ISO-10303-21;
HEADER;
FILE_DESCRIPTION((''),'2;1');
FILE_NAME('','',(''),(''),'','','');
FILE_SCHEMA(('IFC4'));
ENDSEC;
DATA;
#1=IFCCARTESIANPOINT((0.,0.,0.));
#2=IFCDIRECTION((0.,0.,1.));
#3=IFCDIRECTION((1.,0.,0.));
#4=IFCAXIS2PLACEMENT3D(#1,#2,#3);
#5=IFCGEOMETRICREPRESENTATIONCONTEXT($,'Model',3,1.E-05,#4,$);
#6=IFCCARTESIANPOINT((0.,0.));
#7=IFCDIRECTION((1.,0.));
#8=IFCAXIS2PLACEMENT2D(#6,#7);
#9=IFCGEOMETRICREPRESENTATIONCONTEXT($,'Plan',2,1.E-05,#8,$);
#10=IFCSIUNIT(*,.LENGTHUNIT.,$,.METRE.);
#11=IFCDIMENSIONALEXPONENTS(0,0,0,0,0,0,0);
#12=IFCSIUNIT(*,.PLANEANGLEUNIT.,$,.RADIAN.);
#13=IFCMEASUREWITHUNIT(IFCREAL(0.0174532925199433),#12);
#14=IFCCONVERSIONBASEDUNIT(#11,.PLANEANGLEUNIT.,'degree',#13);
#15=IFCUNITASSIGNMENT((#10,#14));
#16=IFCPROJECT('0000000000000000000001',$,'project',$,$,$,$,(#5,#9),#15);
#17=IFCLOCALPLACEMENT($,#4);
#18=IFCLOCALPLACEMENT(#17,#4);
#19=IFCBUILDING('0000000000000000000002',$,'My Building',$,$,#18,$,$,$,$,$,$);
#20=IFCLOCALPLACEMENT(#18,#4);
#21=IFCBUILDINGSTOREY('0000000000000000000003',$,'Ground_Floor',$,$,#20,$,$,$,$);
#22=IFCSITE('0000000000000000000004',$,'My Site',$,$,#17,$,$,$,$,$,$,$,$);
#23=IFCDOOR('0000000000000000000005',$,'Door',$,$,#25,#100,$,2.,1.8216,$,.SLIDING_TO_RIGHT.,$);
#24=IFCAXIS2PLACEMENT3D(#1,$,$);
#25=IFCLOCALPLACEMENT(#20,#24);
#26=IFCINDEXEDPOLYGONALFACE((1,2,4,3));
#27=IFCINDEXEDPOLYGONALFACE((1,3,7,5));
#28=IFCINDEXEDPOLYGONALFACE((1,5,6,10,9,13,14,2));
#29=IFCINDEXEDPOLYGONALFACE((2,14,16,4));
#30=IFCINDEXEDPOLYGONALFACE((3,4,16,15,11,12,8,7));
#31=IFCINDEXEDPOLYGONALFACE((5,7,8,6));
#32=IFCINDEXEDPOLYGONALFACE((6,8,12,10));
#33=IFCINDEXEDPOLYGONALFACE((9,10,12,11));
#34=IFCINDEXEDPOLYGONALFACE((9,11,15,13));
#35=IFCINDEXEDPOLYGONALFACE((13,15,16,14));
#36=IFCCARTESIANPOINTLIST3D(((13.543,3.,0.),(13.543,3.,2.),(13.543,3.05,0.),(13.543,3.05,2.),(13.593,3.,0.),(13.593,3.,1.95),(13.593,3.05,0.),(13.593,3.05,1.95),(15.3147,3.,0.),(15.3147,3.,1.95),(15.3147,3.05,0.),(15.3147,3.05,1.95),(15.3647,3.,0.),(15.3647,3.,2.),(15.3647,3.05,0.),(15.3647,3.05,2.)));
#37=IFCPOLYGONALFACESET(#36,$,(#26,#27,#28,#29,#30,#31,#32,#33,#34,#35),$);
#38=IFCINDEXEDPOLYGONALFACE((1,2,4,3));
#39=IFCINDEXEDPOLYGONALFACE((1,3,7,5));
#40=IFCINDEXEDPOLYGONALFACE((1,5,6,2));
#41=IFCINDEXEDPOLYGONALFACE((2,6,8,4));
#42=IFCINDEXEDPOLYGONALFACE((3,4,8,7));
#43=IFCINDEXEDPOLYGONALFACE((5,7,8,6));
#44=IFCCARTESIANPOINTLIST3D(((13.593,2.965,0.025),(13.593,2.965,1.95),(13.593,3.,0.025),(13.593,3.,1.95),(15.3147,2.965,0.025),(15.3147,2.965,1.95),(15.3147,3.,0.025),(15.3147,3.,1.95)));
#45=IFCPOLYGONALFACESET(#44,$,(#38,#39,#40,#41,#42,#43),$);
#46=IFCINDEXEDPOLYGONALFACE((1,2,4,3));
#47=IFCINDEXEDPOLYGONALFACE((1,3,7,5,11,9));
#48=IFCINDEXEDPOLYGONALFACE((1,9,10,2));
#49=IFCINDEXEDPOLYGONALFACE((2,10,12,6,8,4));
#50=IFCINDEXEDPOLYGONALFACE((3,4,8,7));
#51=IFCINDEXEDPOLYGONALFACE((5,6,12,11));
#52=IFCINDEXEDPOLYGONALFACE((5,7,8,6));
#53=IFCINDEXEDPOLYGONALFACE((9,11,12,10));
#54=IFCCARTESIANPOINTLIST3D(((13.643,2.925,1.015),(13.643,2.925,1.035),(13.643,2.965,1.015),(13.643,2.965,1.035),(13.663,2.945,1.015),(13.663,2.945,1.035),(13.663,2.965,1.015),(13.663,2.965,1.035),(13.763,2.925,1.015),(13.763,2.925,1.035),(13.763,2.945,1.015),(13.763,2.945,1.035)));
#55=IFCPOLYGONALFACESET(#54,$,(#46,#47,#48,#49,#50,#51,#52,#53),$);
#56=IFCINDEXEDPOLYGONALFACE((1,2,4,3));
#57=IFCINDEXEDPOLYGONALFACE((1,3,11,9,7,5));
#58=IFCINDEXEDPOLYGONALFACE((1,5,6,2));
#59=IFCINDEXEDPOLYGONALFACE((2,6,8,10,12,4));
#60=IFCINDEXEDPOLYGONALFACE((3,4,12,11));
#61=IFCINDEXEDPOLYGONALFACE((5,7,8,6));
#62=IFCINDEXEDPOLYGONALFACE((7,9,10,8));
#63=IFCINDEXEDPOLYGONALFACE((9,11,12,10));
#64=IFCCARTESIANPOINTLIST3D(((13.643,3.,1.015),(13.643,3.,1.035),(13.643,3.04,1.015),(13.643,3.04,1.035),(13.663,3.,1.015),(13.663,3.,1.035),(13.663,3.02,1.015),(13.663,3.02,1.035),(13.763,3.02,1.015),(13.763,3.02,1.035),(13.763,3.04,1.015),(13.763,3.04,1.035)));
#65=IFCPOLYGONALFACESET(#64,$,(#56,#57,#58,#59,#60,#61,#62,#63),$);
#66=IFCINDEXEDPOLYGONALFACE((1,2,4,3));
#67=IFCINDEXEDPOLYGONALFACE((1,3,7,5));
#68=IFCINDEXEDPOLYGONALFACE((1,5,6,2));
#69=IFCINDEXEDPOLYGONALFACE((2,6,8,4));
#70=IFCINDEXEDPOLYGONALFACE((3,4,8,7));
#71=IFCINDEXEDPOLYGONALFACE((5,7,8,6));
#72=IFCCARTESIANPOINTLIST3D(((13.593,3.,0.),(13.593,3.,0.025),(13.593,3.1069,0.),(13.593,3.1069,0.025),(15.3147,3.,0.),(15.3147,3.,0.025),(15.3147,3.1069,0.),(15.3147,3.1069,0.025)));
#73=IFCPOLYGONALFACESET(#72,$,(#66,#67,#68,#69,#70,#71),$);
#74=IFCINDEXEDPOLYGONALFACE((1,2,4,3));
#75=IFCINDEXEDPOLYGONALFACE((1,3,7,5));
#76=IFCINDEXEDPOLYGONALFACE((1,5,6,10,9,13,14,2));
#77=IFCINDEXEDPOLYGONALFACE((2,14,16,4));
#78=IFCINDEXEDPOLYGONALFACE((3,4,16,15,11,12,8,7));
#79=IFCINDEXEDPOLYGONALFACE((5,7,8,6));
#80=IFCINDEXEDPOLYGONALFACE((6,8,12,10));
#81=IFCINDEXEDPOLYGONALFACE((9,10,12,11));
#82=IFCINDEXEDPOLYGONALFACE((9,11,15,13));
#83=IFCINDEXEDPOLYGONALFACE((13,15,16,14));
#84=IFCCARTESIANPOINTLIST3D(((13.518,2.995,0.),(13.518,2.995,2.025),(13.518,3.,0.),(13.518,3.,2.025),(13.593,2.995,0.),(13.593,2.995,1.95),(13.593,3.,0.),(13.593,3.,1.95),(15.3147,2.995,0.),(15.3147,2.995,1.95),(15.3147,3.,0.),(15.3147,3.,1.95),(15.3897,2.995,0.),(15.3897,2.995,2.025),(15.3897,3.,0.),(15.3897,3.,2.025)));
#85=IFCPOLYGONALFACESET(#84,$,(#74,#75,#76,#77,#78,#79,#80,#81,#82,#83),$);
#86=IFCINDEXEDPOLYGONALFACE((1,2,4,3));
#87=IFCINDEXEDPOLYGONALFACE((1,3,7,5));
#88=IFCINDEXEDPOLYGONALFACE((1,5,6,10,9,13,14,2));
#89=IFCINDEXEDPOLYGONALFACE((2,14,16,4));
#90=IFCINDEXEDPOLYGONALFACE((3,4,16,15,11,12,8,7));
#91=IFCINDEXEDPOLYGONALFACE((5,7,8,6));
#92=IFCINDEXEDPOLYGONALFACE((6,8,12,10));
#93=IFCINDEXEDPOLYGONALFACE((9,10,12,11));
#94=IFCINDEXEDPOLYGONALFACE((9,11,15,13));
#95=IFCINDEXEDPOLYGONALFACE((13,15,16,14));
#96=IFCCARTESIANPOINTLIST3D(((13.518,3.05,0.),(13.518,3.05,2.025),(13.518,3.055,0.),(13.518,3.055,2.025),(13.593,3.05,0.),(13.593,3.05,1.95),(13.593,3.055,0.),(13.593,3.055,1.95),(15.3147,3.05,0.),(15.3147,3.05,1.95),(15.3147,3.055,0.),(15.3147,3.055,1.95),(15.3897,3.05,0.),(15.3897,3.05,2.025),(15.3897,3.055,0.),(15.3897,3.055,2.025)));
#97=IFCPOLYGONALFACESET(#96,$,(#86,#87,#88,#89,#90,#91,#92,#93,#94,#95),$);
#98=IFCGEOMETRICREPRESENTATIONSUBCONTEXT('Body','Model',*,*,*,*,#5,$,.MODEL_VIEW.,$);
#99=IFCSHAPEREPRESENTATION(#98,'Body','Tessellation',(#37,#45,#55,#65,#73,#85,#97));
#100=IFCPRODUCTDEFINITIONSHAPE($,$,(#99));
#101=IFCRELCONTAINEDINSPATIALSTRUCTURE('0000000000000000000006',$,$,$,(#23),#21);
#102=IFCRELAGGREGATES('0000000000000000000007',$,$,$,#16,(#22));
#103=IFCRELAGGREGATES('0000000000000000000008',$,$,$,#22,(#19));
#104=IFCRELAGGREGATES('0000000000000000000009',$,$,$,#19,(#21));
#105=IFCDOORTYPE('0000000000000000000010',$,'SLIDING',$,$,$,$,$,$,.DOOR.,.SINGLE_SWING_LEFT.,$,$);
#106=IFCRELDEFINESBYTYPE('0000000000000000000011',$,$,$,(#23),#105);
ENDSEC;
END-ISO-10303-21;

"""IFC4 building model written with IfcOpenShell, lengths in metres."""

from ifc_helpers import new_model, entity, si_unit, converted_unit, frame, origin_with_axes, origin_2d_with_axis, place, context, subcontext, project, spatial, line, indexed_curve, outline, extrude, shape, source, transform, mapped, type_object, type_shapes, element, save


model = new_model("IFC4")

# Units and contexts
model_context = context("Model", 3, precision=1e-05, world=origin_with_axes())
plan_context = context("Plan", 2, precision=1e-05, world=origin_2d_with_axis())
body_context_1 = subcontext(model_context, "Body", "Model", "MODEL_VIEW")
body_context_2 = subcontext(plan_context, "Body", "Plan", "PLAN_VIEW")
ifc_project = project(units=[si_unit("LENGTHUNIT", "METRE"), converted_unit("PLANEANGLEUNIT", "degree", entity("IfcReal", 0.0174532925199433), si_unit("PLANEANGLEUNIT", "RADIAN"), dimensions=[0, 0, 0, 0, 0, 0, 0])], contexts=[model_context, plan_context])

# Site, building, storey
site_placement = place(None, origin_with_axes())
site = spatial("IfcSite", under=ifc_project, at=site_placement, Name="My Site")
building_placement = place(site_placement, origin_with_axes())
building = spatial("IfcBuilding", under=site, at=building_placement, Name="My Building")
storey_placement = place(building_placement, origin_with_axes())
storey = spatial("IfcBuildingStorey", under=building, at=storey_placement, Name="Ground_Floor")

# Shared definitions
door_type_1 = type_object("IfcDoorType", Name="SLIDING", OperationType="SINGLE_SWING_LEFT", PredefinedType="DOOR")
shared_shape_1 = source(origin_with_axes(), body_context_1, "Body", "SweptSolid", [
    extrude(outline(indexed_curve([(0.0, 0.0), (0.0, 2.0), (1.8216, 2.0), (1.8216, 0.0), (1.7716, 0.0), (1.7716, 1.95), (0.05, 1.95), (0.05, 0.0)], segments=[line(1, 2, 3, 4, 5, 6, 7, 8, 1)])), frame((0.0, 0.0, 0.0), z_axis=(0.0, -1.0, 0.0), x_axis=(1.0, 0.0, 0.0)), (0.0, 0.0, -1.0), 0.05),
    extrude(outline(indexed_curve([(0.0, 0.0), (1.7216, 0.0), (1.7216, 0.035), (0.0, 0.035)], segments=[line(1, 2, 3, 4, 1)])), frame((0.05, -0.035, 0.025), z_axis=(0.0, 0.0, 1.0), x_axis=(1.0, 0.0, 0.0)), (0.0, 0.0, 1.0), 1.925),
    extrude(outline(indexed_curve([(0.0, 0.0), (0.0, -0.04), (0.12, -0.04), (0.12, -0.02), (0.02, -0.02), (0.02, 0.0)], segments=[line(1, 2, 3, 4, 5, 6, 1)])), frame((0.1, -0.035, 1.015), z_axis=(0.0, 0.0, 1.0), x_axis=(1.0, 0.0, 0.0)), (0.0, 0.0, 1.0), 0.02),
    extrude(outline(indexed_curve([(0.0, 0.0), (0.0, 0.04), (0.12, 0.04), (0.12, 0.02), (0.02, 0.02), (0.02, 0.0)], segments=[line(1, 2, 3, 4, 5, 6, 1)])), frame((0.1, 0.0, 1.015), z_axis=(0.0, 0.0, 1.0), x_axis=(1.0, 0.0, 0.0)), (0.0, 0.0, 1.0), 0.02),
    extrude(outline(indexed_curve([(0.0, 0.0), (1.7216, 0.0), (1.7216, 0.1069), (0.0, 0.1069)], segments=[line(1, 2, 3, 4, 1)])), frame((0.05, 0.0, 0.0), z_axis=(0.0, 0.0, 1.0), x_axis=(1.0, 0.0, 0.0)), (0.0, 0.0, 1.0), 0.025),
    extrude(outline(indexed_curve([(0.0, 0.0), (0.0, 2.025), (1.8716, 2.025), (1.8716, 0.0), (1.7966, 0.0), (1.7966, 1.95), (0.075, 1.95), (0.075, 0.0)], segments=[line(1, 2, 3, 4, 5, 6, 7, 8, 1)])), frame((-0.025, -0.005, 0.0), z_axis=(0.0, -1.0, 0.0), x_axis=(1.0, 0.0, 0.0)), (0.0, 0.0, -1.0), 0.005),
    extrude(outline(indexed_curve([(0.0, 0.0), (0.0, 2.025), (1.8716, 2.025), (1.8716, 0.0), (1.7966, 0.0), (1.7966, 1.95), (0.075, 1.95), (0.075, 0.0)], segments=[line(1, 2, 3, 4, 5, 6, 7, 8, 1)])), frame((-0.025, 0.05, 0.0), z_axis=(0.0, -1.0, 0.0), x_axis=(1.0, 0.0, 0.0)), (0.0, 0.0, -1.0), 0.005),
])
shared_shape_2 = source(origin_with_axes(), body_context_2, "Body", "Curve2D", [
    entity("IfcIndexedPolyCurve", entity("IfcCartesianPointList2D", [[0.0, 0.0], [0.05, 0.0], [0.05, 0.05], [0.0, 0.05]]), [entity("IfcLineIndex", [1, 2, 3, 4, 1])]),
    entity("IfcIndexedPolyCurve", entity("IfcCartesianPointList2D", [[1.8216, 0.0], [1.7716, 0.0], [1.7716, 0.05], [1.8216, 0.05]]), [entity("IfcLineIndex", [1, 2, 3, 4, 1])]),
    entity("IfcIndexedPolyCurve", entity("IfcCartesianPointList2D", [[2.6325, -0.035], [0.9108, -0.035], [0.9108, 0.0], [2.6325, 0.0]]), [entity("IfcLineIndex", [1, 2, 3, 4, 1])]),
])
type_shapes(door_type_1, [shared_shape_1, shared_shape_2])

# Door
door_1_placement = place(storey_placement, frame((13.543, 3.0, 0.0), z_axis=(0.0, 0.0, 1.0), x_axis=(1.0, 0.0, 0.0)))
element("IfcDoor", 1, at=door_1_placement, inside=storey, type_object=door_type_1, Name="Door", OperationType="SLIDING_TO_RIGHT", OverallHeight=2.0, OverallWidth=1.8216, shapes=[
    shape(body_context_1, "Body", "MappedRepresentation", [mapped(shared_shape_1, transform((0.0, 0.0, 0.0), x_axis=(1.0, 0.0, 0.0), y_axis=(0.0, 1.0, 0.0), z_axis=(0.0, 0.0, 1.0), scale=1.0))]),
    shape(body_context_2, "Body", "MappedRepresentation", [mapped(shared_shape_2, transform((0.0, 0.0, 0.0), x_axis=(1.0, 0.0, 0.0), y_axis=(0.0, 1.0, 0.0), z_axis=(0.0, 0.0, 1.0), scale=1.0))]),
])

save(model, "model.ifc")
